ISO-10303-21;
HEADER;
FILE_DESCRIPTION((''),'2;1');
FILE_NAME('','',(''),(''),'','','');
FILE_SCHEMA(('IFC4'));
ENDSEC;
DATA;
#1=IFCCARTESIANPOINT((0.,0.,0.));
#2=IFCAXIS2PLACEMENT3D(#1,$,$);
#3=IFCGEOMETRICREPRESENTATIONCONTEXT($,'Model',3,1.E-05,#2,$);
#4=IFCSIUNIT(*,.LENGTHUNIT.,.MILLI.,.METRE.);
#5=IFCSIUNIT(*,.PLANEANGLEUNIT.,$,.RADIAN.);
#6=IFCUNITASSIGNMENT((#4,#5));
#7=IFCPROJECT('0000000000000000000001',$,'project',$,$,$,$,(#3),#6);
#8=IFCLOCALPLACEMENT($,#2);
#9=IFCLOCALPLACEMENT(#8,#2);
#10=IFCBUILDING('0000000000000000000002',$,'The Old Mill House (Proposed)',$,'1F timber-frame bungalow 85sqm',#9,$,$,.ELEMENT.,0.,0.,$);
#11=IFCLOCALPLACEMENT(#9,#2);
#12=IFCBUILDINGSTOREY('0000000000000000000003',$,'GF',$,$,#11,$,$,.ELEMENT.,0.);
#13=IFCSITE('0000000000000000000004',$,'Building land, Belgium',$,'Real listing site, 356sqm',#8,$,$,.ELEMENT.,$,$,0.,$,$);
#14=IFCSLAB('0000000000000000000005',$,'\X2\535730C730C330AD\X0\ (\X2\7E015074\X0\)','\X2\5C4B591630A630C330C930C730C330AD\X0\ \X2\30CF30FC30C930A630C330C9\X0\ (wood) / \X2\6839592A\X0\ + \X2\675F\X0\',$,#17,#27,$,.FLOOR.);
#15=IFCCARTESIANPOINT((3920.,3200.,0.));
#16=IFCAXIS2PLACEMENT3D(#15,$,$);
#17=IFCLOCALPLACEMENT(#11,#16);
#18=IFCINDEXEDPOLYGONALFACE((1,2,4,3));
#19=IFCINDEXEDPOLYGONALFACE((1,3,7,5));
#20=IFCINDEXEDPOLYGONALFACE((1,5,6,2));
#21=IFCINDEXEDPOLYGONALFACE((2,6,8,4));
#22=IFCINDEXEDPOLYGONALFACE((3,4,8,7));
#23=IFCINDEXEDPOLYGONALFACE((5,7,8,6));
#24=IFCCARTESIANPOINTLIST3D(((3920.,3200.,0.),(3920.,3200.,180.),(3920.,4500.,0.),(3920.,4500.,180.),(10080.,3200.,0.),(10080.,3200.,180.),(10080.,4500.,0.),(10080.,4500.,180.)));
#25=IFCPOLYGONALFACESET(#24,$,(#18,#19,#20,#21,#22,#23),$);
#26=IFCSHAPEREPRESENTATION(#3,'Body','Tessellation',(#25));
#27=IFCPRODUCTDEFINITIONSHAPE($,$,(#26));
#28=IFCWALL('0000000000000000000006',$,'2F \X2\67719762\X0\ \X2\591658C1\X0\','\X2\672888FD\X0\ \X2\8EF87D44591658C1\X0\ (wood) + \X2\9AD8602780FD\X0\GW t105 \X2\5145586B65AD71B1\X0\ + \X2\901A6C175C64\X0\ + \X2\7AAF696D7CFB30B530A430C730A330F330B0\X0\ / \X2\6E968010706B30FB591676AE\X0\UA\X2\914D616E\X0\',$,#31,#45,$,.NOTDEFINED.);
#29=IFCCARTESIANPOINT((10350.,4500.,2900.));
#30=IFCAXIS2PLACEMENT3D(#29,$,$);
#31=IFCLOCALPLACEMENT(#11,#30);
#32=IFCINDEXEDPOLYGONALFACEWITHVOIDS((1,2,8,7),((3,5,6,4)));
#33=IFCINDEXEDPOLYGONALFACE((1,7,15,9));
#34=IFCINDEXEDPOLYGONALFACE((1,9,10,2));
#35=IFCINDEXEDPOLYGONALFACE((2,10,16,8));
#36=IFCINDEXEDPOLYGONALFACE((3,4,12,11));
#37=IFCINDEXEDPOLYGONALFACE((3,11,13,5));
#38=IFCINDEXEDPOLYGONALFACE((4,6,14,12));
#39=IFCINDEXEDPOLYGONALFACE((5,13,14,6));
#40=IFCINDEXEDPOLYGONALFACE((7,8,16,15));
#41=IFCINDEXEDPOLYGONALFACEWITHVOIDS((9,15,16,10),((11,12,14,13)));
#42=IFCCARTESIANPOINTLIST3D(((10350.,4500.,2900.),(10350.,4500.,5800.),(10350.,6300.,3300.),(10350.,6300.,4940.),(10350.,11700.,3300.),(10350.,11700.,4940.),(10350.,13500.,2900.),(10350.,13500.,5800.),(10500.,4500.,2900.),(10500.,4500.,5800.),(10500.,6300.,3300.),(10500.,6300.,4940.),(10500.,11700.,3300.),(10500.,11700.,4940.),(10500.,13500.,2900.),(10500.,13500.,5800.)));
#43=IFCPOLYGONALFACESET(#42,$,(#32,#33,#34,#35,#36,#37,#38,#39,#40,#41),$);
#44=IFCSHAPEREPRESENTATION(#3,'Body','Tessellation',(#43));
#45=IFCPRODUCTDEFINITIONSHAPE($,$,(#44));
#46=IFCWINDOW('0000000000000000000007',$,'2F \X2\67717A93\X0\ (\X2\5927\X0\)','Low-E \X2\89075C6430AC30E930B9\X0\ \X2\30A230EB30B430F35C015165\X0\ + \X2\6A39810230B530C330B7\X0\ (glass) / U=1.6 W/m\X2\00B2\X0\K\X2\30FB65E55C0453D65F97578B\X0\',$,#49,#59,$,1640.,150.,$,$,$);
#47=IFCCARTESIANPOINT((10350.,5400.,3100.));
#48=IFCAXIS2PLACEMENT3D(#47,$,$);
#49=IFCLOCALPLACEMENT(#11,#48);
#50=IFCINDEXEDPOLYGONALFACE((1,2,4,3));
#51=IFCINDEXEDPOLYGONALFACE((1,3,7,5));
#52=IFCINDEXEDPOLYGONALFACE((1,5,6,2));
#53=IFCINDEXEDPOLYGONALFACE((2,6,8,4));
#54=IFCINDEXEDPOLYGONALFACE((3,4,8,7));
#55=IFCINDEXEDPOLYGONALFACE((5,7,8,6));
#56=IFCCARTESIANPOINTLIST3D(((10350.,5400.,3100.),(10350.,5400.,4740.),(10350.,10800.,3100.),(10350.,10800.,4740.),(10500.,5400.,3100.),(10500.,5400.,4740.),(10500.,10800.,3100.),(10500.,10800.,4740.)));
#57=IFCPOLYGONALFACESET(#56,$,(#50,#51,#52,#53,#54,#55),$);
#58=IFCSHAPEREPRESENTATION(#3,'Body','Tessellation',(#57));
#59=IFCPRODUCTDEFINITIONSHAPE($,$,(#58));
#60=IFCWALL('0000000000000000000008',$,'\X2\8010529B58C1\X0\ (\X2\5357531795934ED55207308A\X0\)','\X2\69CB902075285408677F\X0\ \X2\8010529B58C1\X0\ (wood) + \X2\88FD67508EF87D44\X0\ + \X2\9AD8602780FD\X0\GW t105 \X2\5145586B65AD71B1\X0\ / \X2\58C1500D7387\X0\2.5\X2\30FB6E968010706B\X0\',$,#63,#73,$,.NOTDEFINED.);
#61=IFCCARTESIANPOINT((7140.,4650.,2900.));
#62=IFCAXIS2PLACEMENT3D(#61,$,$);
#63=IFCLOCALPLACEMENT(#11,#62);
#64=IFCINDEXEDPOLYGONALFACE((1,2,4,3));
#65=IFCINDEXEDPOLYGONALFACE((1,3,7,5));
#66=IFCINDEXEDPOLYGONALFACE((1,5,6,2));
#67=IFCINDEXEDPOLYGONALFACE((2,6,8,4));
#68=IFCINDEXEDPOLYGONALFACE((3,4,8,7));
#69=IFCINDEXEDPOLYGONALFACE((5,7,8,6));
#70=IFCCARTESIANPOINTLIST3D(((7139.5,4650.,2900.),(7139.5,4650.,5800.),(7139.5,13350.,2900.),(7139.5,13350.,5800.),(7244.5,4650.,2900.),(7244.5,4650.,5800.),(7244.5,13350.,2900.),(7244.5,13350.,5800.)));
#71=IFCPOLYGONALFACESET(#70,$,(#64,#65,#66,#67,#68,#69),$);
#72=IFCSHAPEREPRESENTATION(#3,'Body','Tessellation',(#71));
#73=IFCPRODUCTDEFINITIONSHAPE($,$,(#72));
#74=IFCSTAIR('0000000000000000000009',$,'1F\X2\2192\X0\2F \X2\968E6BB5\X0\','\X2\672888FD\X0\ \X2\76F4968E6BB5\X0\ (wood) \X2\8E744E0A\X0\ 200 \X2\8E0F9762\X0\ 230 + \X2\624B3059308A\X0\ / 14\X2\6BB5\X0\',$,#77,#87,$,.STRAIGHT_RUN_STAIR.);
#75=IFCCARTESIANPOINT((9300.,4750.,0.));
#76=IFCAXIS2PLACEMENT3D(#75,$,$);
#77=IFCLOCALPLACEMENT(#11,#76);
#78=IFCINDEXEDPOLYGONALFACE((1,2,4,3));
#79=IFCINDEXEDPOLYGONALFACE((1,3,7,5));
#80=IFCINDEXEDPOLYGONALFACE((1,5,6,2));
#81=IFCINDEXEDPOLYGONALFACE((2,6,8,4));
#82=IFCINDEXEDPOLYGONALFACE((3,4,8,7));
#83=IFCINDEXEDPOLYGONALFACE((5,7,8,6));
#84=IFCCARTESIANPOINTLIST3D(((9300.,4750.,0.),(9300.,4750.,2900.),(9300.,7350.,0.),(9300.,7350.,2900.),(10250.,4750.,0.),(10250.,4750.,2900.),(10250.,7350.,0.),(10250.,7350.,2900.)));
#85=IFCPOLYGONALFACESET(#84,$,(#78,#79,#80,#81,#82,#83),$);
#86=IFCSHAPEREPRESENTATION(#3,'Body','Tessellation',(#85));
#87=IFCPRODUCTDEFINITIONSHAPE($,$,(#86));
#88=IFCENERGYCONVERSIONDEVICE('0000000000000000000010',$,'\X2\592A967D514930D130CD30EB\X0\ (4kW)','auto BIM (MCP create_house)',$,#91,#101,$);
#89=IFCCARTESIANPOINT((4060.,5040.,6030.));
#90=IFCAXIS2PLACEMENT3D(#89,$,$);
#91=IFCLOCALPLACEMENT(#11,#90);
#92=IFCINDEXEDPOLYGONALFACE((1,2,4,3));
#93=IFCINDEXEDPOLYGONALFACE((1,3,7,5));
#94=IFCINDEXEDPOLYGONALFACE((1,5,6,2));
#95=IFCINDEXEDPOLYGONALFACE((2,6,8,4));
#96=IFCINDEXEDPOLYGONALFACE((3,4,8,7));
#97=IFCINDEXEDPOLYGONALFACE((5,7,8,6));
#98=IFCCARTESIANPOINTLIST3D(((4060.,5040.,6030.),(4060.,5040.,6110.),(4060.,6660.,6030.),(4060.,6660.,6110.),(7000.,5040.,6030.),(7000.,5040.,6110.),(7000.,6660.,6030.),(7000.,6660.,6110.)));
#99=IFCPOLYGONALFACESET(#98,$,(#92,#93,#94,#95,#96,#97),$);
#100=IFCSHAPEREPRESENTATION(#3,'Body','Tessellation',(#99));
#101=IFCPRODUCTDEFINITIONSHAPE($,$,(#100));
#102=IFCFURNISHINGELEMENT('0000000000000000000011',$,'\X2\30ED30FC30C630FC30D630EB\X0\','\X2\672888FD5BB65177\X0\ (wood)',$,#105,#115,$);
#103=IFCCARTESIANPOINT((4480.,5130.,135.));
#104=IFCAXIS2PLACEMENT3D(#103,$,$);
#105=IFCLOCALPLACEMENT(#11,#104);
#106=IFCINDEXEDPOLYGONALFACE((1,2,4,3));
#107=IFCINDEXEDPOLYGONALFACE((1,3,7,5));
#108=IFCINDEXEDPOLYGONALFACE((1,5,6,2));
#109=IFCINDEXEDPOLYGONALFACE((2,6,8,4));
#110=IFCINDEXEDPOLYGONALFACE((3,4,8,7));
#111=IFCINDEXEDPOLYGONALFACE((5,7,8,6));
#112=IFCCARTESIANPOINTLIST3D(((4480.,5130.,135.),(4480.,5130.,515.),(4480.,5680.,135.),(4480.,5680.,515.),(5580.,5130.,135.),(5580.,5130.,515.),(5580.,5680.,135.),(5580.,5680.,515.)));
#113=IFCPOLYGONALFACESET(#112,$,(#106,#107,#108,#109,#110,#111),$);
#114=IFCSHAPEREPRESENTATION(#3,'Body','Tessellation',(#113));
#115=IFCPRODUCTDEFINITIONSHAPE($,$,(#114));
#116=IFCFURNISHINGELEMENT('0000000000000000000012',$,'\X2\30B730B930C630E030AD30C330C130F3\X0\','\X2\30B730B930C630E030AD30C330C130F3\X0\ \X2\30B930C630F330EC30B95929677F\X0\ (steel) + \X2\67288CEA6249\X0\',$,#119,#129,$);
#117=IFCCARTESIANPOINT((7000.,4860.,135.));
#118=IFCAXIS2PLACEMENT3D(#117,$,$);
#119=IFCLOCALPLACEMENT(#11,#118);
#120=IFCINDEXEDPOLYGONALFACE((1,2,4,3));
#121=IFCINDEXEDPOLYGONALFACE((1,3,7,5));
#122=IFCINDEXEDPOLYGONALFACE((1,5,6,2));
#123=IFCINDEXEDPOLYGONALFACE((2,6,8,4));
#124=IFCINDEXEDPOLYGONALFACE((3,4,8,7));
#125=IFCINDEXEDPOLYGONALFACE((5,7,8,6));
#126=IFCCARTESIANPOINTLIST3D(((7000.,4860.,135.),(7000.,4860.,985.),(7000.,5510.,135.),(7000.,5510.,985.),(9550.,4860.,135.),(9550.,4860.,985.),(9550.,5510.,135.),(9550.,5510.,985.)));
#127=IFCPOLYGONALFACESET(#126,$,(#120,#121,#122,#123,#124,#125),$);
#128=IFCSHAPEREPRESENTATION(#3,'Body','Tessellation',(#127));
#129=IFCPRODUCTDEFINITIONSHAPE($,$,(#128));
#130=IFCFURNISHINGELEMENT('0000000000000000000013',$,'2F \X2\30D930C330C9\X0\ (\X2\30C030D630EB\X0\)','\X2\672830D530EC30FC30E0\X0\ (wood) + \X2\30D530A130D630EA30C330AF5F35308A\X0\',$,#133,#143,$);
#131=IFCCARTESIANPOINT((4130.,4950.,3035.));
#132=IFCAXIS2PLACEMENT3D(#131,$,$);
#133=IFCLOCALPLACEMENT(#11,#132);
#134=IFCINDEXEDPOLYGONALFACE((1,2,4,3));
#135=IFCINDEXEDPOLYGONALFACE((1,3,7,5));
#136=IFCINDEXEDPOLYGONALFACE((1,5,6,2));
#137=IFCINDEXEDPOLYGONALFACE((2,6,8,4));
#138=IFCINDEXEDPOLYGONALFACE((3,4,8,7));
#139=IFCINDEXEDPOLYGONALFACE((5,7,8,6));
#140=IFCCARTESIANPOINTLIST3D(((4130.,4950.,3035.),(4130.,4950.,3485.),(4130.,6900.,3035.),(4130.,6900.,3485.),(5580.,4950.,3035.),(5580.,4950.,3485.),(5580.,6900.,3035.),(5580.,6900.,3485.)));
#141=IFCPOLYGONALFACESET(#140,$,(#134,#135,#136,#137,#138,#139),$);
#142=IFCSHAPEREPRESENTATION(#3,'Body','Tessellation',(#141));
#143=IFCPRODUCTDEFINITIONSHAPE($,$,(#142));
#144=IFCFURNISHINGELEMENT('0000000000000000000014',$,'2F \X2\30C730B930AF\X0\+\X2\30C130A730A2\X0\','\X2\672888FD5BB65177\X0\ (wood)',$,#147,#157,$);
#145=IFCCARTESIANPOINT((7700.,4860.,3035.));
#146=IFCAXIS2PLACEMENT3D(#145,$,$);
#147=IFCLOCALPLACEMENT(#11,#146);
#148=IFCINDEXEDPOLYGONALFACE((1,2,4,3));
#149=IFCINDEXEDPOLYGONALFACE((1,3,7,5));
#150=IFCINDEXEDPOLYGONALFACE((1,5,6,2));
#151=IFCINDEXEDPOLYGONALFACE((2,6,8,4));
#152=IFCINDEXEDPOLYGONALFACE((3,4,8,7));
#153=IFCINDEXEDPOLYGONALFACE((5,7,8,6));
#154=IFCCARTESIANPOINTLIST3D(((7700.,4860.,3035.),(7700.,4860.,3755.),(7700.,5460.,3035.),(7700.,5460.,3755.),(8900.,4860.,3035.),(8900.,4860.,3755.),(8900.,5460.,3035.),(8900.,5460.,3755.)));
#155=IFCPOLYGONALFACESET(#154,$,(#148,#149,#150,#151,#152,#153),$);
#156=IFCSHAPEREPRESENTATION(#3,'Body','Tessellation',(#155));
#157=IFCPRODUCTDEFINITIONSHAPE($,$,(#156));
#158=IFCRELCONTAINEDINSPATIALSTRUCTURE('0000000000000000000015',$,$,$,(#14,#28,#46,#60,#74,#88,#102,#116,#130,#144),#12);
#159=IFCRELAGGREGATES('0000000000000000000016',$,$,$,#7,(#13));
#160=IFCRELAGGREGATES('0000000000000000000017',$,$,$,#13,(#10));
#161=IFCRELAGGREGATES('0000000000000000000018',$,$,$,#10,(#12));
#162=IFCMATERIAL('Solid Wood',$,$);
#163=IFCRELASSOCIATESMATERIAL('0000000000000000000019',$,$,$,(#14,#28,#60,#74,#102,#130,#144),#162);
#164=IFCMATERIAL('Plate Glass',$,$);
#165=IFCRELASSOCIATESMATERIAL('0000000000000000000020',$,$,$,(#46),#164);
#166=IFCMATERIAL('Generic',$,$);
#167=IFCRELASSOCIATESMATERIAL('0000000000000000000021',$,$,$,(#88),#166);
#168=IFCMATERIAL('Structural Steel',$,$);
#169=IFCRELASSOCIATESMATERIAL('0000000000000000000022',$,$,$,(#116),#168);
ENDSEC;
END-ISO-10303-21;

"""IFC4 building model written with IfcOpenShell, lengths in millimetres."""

from ifc_helpers import new_model, si_unit, frame, frame_2d, origin, place, context, project, spatial, rectangle, extrude, material, element, fill, save


model = new_model("IFC4")

# Units and contexts
model_context = context("Model", 3, precision=1e-05, world=origin())
ifc_project = project(units=[si_unit("LENGTHUNIT", "METRE", prefix="MILLI"), si_unit("PLANEANGLEUNIT", "RADIAN")], contexts=[model_context])

# Site, building, storey
site_placement = place(None, origin())
site = spatial("IfcSite", under=ifc_project, at=site_placement, Name="Building land, Belgium", ObjectType="Real listing site, 356sqm", CompositionType="ELEMENT", RefElevation=0.0)
building_placement = place(site_placement, origin())
building = spatial("IfcBuilding", under=site, at=building_placement, Name="The Old Mill House (Proposed)", ObjectType="1F timber-frame bungalow 85sqm", CompositionType="ELEMENT", ElevationOfRefHeight=0.0, ElevationOfTerrain=0.0)
storey_placement = place(building_placement, origin())
storey = spatial("IfcBuildingStorey", under=building, at=storey_placement, Name="GF", CompositionType="ELEMENT", Elevation=0.0)

# Slab
ifc_material_1 = material(Name="Solid Wood")
slab_placement = place(storey_placement, frame((3920.0, 3200.0, 0.0)))
element("IfcSlab", 1, at=slab_placement, inside=storey, material=ifc_material_1, Name="南デッキ (縁側)", Description="屋外ウッドデッキ ハードウッド (wood) / 根太 + 束", PredefinedType="FLOOR", context=model_context, shape_type="SweptSolid", body=[
    extrude(rectangle(XDim=6160.0, YDim=1300.0, at=frame_2d((3080.0, 650.0))), frame((3920.0, 3200.0, 0.0)), (0.0, 0.0, 1.0), 180.0),
])

# Shared definitions
ifc_material_2 = material(Name="Plate Glass")

# Wall, opening, window
wall_1_placement = place(storey_placement, frame((10350.0, 4500.0, 2900.0)))
wall_1 = element("IfcWall", 2, at=wall_1_placement, inside=storey, material=ifc_material_1, Name="2F 東面 外壁", Description="木製 軸組外壁 (wood) + 高性能GW t105 充填断熱 + 通気層 + 窯業系サイディング / 準耐火・外皮UA配慮", PredefinedType="NOTDEFINED", context=model_context, shape_type="SweptSolid", body=[
    extrude(rectangle(XDim=150.0, YDim=9000.0, at=frame_2d((75.0, 4500.0))), frame((10350.0, 4500.0, 2900.0)), (0.0, 0.0, 1.0), 2900.0),
])
opening_1_placement = place(storey_placement, frame((10350.0, 5400.0, 3100.0)))
opening_1 = element("IfcOpeningElement", 3, at=opening_1_placement, cuts=wall_1, PredefinedType="NOTDEFINED", context=model_context, shape_type="SweptSolid", body=[
    extrude(rectangle(XDim=150.0, YDim=5400.0, at=frame_2d((75.0, 2700.0))), frame((10350.0, 5400.0, 3100.0)), (0.0, 0.0, 1.0), 1640.0),
])
window_1_placement = place(storey_placement, frame((10350.0, 5400.0, 3100.0)))
window_1 = element("IfcWindow", 4, at=window_1_placement, inside=storey, material=ifc_material_2, Name="2F 東窓 (大)", Description="Low-E 複層ガラス アルゴン封入 + 樹脂サッシ (glass) / U=1.6 W/m²K・日射取得型", OverallHeight=1640.0, OverallWidth=150.0, context=model_context, shape_type="SweptSolid", body=[
    extrude(rectangle(XDim=150.0, YDim=5400.0, at=frame_2d((75.0, 2700.0))), frame((10350.0, 5400.0, 3100.0)), (0.0, 0.0, 1.0), 1640.0),
])
fill(opening_1, window_1)

# Wall
wall_2_placement = place(storey_placement, frame((7140.0, 4650.0, 2900.0)))
element("IfcWall", 5, at=wall_2_placement, inside=storey, material=ifc_material_1, Name="耐力壁 (南北間仕切り)", Description="構造用合板 耐力壁 (wood) + 製材軸組 + 高性能GW t105 充填断熱 / 壁倍率2.5・準耐火", PredefinedType="NOTDEFINED", context=model_context, shape_type="SweptSolid", body=[
    extrude(rectangle(XDim=105.0, YDim=8700.0, at=frame_2d((52.0, 4350.0))), frame((7140.0, 4650.0, 2900.0)), (0.0, 0.0, 1.0), 2900.0),
])

# Stair
stair_placement = place(storey_placement, frame((9300.0, 4750.0, 0.0)))
element("IfcStair", 6, at=stair_placement, inside=storey, material=ifc_material_1, Name="1F→2F 階段", Description="木製 直階段 (wood) 蹴上 200 踏面 230 + 手すり / 14段", PredefinedType="STRAIGHT_RUN_STAIR", context=model_context, shape_type="SweptSolid", body=[
    extrude(rectangle(XDim=950.0, YDim=2600.0, at=frame_2d((475.0, 1300.0))), frame((9300.0, 4750.0, 0.0)), (0.0, 0.0, 1.0), 2900.0),
])

# Energy conversion device
ifc_material_3 = material(Name="Generic")
energy_conversion_device_placement = place(storey_placement, frame((4060.0, 5040.0, 6030.0)))
element("IfcEnergyConversionDevice", 7, at=energy_conversion_device_placement, inside=storey, material=ifc_material_3, Name="太陽光パネル (4kW)", Description="auto BIM (MCP create_house)", context=model_context, shape_type="SweptSolid", body=[
    extrude(rectangle(XDim=2940.0, YDim=1620.0, at=frame_2d((1470.0, 810.0))), frame((4060.0, 5040.0, 6030.0)), (0.0, 0.0, 1.0), 80.0),
])

# Furnishing elements
furnishing_1_placement = place(storey_placement, frame((4480.0, 5130.0, 135.0)))
element("IfcFurnishingElement", 8, at=furnishing_1_placement, inside=storey, material=ifc_material_1, Name="ローテーブル", Description="木製家具 (wood)", context=model_context, shape_type="SweptSolid", body=[
    extrude(rectangle(XDim=1100.0, YDim=550.0, at=frame_2d((550.0, 275.0))), frame((4480.0, 5130.0, 135.0)), (0.0, 0.0, 1.0), 380.0),
])
ifc_material_4 = material(Name="Structural Steel")
furnishing_2_placement = place(storey_placement, frame((7000.0, 4860.0, 135.0)))
element("IfcFurnishingElement", 9, at=furnishing_2_placement, inside=storey, material=ifc_material_4, Name="システムキッチン", Description="システムキッチン ステンレス天板 (steel) + 木質扉", context=model_context, shape_type="SweptSolid", body=[
    extrude(rectangle(XDim=2550.0, YDim=650.0, at=frame_2d((1275.0, 325.0))), frame((7000.0, 4860.0, 135.0)), (0.0, 0.0, 1.0), 850.0),
])
furnishing_3_placement = place(storey_placement, frame((4130.0, 4950.0, 3035.0)))
element("IfcFurnishingElement", 10, at=furnishing_3_placement, inside=storey, material=ifc_material_1, Name="2F ベッド (ダブル)", Description="木フレーム (wood) + ファブリック張り", context=model_context, shape_type="SweptSolid", body=[
    extrude(rectangle(XDim=1450.0, YDim=1950.0, at=frame_2d((725.0, 975.0))), frame((4130.0, 4950.0, 3035.0)), (0.0, 0.0, 1.0), 450.0),
])
furnishing_4_placement = place(storey_placement, frame((7700.0, 4860.0, 3035.0)))
element("IfcFurnishingElement", 11, at=furnishing_4_placement, inside=storey, material=ifc_material_1, Name="2F デスク+チェア", Description="木製家具 (wood)", context=model_context, shape_type="SweptSolid", body=[
    extrude(rectangle(XDim=1200.0, YDim=600.0, at=frame_2d((600.0, 300.0))), frame((7700.0, 4860.0, 3035.0)), (0.0, 0.0, 1.0), 720.0),
])

save(model, "model.ifc")
